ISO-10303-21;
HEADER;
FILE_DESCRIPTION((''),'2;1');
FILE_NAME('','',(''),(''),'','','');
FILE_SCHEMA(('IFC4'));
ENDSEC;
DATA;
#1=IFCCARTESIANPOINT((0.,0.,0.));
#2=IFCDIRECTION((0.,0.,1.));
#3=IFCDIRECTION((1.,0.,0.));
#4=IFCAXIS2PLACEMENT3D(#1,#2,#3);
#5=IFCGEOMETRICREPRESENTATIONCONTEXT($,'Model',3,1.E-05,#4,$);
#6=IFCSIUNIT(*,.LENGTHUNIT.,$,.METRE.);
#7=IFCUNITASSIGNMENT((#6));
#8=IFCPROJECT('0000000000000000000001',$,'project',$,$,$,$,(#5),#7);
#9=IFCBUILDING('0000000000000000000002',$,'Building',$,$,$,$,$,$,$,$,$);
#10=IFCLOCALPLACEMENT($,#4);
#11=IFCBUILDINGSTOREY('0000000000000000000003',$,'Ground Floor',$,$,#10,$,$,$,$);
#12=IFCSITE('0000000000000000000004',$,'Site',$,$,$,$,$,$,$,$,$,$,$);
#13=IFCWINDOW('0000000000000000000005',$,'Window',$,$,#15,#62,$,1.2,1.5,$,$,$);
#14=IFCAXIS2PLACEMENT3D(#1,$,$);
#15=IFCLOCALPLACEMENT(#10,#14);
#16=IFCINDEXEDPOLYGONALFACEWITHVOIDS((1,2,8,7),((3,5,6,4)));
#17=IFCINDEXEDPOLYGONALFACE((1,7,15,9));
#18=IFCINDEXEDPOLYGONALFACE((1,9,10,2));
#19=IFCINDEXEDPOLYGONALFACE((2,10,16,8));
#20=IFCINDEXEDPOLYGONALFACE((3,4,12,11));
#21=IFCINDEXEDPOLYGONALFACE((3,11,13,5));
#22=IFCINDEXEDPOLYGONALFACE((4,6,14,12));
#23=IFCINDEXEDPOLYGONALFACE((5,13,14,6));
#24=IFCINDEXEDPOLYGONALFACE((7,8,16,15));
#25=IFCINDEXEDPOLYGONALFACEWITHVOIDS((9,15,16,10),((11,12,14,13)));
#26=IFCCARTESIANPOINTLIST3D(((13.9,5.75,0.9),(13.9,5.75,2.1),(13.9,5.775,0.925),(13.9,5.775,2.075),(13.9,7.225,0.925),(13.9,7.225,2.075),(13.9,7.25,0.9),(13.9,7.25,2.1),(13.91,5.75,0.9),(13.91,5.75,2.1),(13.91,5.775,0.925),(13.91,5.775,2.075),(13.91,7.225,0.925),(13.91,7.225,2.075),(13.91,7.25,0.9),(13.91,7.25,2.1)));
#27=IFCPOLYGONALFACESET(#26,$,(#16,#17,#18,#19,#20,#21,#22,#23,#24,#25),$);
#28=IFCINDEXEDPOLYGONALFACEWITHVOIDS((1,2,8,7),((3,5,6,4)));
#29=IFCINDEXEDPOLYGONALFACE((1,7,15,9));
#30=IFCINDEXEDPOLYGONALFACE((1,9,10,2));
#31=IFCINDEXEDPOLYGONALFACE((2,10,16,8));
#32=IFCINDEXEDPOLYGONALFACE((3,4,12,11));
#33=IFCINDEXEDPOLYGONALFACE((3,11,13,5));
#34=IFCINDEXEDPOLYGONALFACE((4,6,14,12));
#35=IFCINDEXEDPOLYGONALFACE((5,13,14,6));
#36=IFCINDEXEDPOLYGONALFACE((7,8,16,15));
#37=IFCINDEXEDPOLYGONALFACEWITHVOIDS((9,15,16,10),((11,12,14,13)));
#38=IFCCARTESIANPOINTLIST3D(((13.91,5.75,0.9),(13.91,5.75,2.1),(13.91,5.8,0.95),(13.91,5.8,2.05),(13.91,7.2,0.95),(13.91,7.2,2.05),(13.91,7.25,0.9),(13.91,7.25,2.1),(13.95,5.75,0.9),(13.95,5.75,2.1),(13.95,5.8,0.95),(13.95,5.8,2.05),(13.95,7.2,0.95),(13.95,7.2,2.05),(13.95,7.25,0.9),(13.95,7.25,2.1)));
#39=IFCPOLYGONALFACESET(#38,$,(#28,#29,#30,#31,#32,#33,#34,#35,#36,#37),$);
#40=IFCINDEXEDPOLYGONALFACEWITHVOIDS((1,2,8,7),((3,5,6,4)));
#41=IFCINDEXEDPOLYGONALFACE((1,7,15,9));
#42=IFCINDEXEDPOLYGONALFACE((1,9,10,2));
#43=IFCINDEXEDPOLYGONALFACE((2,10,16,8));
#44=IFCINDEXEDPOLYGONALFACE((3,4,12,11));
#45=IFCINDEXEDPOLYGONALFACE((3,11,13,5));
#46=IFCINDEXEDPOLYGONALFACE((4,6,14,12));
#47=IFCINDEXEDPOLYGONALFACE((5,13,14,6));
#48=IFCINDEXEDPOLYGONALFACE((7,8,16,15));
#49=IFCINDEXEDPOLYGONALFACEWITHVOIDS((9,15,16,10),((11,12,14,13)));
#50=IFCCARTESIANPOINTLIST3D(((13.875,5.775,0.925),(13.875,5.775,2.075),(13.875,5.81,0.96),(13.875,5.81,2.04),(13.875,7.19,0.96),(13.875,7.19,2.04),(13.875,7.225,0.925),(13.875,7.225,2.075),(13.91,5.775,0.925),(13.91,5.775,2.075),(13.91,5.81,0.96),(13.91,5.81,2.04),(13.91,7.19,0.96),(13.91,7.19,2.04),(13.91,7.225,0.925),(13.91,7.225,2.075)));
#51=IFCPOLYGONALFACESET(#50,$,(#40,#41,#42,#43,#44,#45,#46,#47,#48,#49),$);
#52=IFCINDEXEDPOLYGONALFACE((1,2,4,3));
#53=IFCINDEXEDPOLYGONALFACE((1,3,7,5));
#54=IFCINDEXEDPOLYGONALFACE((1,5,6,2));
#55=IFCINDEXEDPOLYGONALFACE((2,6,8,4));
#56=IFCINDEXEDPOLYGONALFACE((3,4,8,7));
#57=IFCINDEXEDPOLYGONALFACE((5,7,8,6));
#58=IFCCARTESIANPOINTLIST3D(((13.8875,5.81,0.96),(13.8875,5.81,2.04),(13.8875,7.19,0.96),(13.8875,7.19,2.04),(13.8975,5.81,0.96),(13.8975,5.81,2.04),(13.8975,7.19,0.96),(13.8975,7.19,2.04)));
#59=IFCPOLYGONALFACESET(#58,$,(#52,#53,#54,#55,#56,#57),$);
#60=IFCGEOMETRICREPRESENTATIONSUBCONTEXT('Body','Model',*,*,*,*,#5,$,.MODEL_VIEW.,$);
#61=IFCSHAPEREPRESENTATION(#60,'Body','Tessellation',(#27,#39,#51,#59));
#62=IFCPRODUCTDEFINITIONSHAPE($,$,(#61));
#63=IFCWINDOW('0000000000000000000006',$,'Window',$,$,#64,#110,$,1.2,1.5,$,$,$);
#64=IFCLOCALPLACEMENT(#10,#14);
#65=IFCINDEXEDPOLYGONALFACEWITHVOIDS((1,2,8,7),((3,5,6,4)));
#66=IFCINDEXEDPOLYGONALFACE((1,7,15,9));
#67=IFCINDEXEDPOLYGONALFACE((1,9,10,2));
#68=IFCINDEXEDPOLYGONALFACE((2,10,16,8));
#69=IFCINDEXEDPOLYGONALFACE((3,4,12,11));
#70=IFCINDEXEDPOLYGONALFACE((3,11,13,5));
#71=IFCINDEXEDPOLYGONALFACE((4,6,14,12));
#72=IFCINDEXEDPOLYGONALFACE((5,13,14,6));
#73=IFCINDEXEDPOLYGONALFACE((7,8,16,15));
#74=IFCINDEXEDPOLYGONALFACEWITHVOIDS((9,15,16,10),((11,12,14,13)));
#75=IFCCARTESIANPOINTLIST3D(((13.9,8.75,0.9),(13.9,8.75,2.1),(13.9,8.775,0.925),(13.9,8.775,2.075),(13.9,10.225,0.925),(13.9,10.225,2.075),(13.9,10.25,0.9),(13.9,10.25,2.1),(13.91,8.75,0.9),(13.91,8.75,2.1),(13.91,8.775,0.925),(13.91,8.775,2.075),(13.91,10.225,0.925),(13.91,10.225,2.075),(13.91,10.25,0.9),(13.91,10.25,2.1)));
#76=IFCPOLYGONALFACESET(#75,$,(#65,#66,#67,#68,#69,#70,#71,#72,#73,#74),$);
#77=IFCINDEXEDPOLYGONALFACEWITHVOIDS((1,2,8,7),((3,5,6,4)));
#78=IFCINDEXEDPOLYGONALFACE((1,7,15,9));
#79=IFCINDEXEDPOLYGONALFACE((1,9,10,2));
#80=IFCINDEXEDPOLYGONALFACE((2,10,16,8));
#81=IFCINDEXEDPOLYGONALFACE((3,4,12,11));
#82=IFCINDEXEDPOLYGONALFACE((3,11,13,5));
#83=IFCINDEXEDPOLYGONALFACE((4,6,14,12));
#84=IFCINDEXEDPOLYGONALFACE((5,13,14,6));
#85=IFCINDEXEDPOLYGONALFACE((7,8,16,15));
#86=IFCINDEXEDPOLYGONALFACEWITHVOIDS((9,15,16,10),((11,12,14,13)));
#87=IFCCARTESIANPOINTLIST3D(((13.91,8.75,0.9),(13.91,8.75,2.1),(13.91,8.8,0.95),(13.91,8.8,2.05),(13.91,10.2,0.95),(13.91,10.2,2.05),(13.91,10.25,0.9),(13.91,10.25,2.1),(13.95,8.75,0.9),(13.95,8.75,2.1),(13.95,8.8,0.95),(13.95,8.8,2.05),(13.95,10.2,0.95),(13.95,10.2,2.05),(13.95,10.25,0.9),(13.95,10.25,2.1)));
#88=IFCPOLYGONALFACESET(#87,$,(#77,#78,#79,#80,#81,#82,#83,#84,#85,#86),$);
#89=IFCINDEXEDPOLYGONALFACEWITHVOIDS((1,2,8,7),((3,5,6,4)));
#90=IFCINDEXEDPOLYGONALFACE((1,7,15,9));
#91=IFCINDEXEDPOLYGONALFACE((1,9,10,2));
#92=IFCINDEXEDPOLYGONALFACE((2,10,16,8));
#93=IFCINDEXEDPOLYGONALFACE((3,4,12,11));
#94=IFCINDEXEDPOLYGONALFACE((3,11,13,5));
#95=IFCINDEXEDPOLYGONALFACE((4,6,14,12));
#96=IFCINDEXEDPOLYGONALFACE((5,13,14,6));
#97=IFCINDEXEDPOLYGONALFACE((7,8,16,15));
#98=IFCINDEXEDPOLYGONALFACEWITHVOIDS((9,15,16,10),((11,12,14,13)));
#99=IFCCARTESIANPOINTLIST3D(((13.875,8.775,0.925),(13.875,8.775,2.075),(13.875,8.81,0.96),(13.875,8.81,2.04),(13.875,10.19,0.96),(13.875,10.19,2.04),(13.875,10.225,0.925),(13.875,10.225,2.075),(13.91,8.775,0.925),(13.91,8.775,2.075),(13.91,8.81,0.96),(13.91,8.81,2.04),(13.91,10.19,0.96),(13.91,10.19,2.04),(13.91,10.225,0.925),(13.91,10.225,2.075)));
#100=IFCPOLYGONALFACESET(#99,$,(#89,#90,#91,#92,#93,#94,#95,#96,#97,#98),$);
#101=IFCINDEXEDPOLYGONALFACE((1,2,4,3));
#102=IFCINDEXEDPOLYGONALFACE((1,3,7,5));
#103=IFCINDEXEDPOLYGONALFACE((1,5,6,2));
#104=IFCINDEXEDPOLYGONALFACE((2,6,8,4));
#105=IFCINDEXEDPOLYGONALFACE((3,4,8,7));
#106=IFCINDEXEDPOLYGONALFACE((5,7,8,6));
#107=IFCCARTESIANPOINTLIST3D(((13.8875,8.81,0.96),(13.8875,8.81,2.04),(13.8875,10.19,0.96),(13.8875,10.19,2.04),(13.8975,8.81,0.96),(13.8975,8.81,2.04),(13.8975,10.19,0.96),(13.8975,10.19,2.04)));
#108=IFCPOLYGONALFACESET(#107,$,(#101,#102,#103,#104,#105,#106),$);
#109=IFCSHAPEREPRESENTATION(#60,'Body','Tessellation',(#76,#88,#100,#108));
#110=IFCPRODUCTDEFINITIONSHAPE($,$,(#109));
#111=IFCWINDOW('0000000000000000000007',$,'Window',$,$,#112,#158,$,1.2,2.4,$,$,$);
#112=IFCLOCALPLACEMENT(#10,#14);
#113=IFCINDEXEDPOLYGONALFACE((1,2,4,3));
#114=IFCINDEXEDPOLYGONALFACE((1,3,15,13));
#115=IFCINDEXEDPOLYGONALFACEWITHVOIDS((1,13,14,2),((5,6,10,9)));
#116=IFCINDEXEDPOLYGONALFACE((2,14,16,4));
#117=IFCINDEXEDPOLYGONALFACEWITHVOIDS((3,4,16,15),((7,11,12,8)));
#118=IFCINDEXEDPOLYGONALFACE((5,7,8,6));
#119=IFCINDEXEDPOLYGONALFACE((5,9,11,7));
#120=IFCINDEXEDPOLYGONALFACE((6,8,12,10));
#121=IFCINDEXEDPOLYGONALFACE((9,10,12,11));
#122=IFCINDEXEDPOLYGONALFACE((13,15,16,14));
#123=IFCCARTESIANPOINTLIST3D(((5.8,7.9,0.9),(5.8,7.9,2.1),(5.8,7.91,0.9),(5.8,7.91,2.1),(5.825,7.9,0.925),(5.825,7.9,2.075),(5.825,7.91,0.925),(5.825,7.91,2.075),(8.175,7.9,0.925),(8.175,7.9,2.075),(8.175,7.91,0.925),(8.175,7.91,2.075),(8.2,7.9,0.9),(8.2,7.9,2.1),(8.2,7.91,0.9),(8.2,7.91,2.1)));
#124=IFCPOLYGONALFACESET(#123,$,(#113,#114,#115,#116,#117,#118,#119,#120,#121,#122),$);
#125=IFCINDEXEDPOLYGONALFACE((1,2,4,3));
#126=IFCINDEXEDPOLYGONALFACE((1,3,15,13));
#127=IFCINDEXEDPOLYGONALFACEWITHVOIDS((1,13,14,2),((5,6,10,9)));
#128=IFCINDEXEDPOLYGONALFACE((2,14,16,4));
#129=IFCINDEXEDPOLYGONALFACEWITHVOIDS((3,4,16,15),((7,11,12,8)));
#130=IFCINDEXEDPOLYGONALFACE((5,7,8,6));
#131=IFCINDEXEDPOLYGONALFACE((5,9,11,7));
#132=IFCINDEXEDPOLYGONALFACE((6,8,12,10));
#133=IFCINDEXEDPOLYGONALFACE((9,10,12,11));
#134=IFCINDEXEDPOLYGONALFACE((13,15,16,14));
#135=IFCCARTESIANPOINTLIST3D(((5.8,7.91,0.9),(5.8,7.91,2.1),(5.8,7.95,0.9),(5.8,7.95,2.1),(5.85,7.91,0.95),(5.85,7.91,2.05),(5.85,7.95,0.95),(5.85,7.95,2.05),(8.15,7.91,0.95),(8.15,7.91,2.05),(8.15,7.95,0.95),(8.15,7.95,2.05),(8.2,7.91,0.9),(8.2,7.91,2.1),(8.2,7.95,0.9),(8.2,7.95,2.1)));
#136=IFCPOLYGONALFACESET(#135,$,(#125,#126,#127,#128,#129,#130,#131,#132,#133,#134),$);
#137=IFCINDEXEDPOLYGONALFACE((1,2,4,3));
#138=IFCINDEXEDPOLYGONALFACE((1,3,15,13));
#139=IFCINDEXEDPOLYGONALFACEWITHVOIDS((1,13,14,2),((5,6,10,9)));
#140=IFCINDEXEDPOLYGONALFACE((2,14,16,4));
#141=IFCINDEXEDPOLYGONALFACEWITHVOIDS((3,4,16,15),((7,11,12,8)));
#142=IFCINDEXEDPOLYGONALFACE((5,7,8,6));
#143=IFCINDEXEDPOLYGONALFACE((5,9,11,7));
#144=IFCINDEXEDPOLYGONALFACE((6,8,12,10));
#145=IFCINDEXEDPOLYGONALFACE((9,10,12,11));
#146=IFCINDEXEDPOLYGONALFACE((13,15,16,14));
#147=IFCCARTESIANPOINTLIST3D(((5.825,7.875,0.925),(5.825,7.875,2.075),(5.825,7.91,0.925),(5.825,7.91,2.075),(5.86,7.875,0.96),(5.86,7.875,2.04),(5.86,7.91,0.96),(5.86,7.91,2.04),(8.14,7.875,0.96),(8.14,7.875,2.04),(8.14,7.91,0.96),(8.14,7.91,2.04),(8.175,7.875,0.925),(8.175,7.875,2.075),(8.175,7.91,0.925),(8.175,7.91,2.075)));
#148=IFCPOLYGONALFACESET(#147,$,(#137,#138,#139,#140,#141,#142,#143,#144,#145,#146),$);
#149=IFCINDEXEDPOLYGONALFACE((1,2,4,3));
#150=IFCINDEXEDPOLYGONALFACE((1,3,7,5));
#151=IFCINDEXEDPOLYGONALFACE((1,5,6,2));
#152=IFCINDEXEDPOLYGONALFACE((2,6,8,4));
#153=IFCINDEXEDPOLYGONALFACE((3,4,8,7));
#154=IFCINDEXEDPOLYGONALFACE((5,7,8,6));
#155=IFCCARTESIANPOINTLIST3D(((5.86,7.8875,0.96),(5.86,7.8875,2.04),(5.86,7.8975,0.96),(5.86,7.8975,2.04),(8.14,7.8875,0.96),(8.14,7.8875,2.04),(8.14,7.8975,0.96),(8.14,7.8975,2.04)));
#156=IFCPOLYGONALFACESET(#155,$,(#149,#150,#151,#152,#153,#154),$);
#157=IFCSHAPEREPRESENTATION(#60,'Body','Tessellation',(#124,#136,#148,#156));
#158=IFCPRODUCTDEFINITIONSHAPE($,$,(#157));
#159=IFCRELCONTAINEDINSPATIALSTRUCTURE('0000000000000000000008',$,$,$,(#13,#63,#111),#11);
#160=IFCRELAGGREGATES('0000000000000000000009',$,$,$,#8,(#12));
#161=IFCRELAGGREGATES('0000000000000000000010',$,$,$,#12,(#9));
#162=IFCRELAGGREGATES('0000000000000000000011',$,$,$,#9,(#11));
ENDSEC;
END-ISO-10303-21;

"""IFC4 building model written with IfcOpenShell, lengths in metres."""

from ifc_helpers import new_model, si_unit, frame, origin_with_axes, place, context, subcontext, project, spatial, line, indexed_curve, outline, extrude, element, save


model = new_model("IFC4")

# Units and contexts
model_context = context("Model", 3, precision=1e-05, world=origin_with_axes())
body_context = subcontext(model_context, "Body", "Model", "MODEL_VIEW")
ifc_project = project(units=[si_unit("LENGTHUNIT", "METRE")], contexts=[model_context])

# Site, building, storey
site = spatial("IfcSite", under=ifc_project, Name="Site")
building = spatial("IfcBuilding", under=site, Name="Building")
storey_placement = place(None, origin_with_axes())
storey = spatial("IfcBuildingStorey", under=building, at=storey_placement, Name="Ground Floor")

# Windows
for number, where, z_axis, x_axis, name in (
    (1, (14.0, 5.75, 0.9), (0.0, 0.0, 1.0), (0.0, 1.0, 0.0), "Window"),
    (2, (14.0, 8.75, 0.9), (0.0, 0.0, 1.0), (0.0, 1.0, 0.0), "Window"),
):
    element("IfcWindow", number, at=place(storey_placement, frame(where, z_axis=z_axis, x_axis=x_axis)), inside=storey, Name=name, OverallHeight=1.2, OverallWidth=1.5, context=body_context, shape_type="SweptSolid", body=[
        extrude(outline(indexed_curve([(0.0, 0.0), (1.5, 0.0), (1.5, 1.2), (0.0, 1.2)], segments=[line(1, 2, 3, 4, 1)]), holes=[indexed_curve([(0.025, 0.025), (1.475, 0.025), (1.475, 1.175), (0.025, 1.175)], segments=[line(1, 2, 3, 4, 1)])]), frame((0.0, 0.09, 0.0), z_axis=(0.0, -1.0, 0.0), x_axis=(1.0, 0.0, 0.0)), (0.0, 0.0, -1.0), 0.01),
        extrude(outline(indexed_curve([(0.0, 0.0), (1.5, 0.0), (1.5, 1.2), (0.0, 1.2)], segments=[line(1, 2, 3, 4, 1)]), holes=[indexed_curve([(0.05, 0.05), (1.45, 0.05), (1.45, 1.15), (0.05, 1.15)], segments=[line(1, 2, 3, 4, 1)])]), frame((0.0, 0.05, 0.0), z_axis=(0.0, -1.0, 0.0), x_axis=(1.0, 0.0, 0.0)), (0.0, 0.0, -1.0), 0.04),
        extrude(outline(indexed_curve([(0.0, 0.0), (1.45, 0.0), (1.45, 1.15), (0.0, 1.15)], segments=[line(1, 2, 3, 4, 1)]), holes=[indexed_curve([(0.035, 0.035), (1.415, 0.035), (1.415, 1.115), (0.035, 1.115)], segments=[line(1, 2, 3, 4, 1)])]), frame((0.025, 0.09, 0.025), z_axis=(0.0, -1.0, 0.0), x_axis=(1.0, 0.0, 0.0)), (0.0, 0.0, -1.0), 0.035),
        extrude(outline(indexed_curve([(0.035, 0.035), (1.415, 0.035), (1.415, 1.115), (0.035, 1.115)], segments=[line(1, 2, 3, 4, 1)])), frame((0.025, 0.1025, 0.025), z_axis=(0.0, -1.0, 0.0), x_axis=(1.0, 0.0, 0.0)), (0.0, 0.0, -1.0), 0.01),
    ])
window_1_placement = place(storey_placement, frame((8.2, 8.0, 0.9), z_axis=(0.0, 0.0, 1.0), x_axis=(-1.0, 0.0, 0.0)))
element("IfcWindow", 3, at=window_1_placement, inside=storey, Name="Window", OverallHeight=1.2, OverallWidth=2.4, context=body_context, shape_type="SweptSolid", body=[
    extrude(outline(indexed_curve([(0.0, 0.0), (2.4, 0.0), (2.4, 1.2), (0.0, 1.2)], segments=[line(1, 2, 3, 4, 1)]), holes=[indexed_curve([(0.025, 0.025), (2.375, 0.025), (2.375, 1.175), (0.025, 1.175)], segments=[line(1, 2, 3, 4, 1)])]), frame((0.0, 0.09, 0.0), z_axis=(0.0, -1.0, 0.0), x_axis=(1.0, 0.0, 0.0)), (0.0, 0.0, -1.0), 0.01),
    extrude(outline(indexed_curve([(0.0, 0.0), (2.4, 0.0), (2.4, 1.2), (0.0, 1.2)], segments=[line(1, 2, 3, 4, 1)]), holes=[indexed_curve([(0.05, 0.05), (2.35, 0.05), (2.35, 1.15), (0.05, 1.15)], segments=[line(1, 2, 3, 4, 1)])]), frame((0.0, 0.05, 0.0), z_axis=(0.0, -1.0, 0.0), x_axis=(1.0, 0.0, 0.0)), (0.0, 0.0, -1.0), 0.04),
    extrude(outline(indexed_curve([(0.0, 0.0), (2.35, 0.0), (2.35, 1.15), (0.0, 1.15)], segments=[line(1, 2, 3, 4, 1)]), holes=[indexed_curve([(0.035, 0.035), (2.315, 0.035), (2.315, 1.115), (0.035, 1.115)], segments=[line(1, 2, 3, 4, 1)])]), frame((0.025, 0.09, 0.025), z_axis=(0.0, -1.0, 0.0), x_axis=(1.0, 0.0, 0.0)), (0.0, 0.0, -1.0), 0.035),
    extrude(outline(indexed_curve([(0.035, 0.035), (2.315, 0.035), (2.315, 1.115), (0.035, 1.115)], segments=[line(1, 2, 3, 4, 1)])), frame((0.025, 0.1025, 0.025), z_axis=(0.0, -1.0, 0.0), x_axis=(1.0, 0.0, 0.0)), (0.0, 0.0, -1.0), 0.01),
])

save(model, "model.ifc")
